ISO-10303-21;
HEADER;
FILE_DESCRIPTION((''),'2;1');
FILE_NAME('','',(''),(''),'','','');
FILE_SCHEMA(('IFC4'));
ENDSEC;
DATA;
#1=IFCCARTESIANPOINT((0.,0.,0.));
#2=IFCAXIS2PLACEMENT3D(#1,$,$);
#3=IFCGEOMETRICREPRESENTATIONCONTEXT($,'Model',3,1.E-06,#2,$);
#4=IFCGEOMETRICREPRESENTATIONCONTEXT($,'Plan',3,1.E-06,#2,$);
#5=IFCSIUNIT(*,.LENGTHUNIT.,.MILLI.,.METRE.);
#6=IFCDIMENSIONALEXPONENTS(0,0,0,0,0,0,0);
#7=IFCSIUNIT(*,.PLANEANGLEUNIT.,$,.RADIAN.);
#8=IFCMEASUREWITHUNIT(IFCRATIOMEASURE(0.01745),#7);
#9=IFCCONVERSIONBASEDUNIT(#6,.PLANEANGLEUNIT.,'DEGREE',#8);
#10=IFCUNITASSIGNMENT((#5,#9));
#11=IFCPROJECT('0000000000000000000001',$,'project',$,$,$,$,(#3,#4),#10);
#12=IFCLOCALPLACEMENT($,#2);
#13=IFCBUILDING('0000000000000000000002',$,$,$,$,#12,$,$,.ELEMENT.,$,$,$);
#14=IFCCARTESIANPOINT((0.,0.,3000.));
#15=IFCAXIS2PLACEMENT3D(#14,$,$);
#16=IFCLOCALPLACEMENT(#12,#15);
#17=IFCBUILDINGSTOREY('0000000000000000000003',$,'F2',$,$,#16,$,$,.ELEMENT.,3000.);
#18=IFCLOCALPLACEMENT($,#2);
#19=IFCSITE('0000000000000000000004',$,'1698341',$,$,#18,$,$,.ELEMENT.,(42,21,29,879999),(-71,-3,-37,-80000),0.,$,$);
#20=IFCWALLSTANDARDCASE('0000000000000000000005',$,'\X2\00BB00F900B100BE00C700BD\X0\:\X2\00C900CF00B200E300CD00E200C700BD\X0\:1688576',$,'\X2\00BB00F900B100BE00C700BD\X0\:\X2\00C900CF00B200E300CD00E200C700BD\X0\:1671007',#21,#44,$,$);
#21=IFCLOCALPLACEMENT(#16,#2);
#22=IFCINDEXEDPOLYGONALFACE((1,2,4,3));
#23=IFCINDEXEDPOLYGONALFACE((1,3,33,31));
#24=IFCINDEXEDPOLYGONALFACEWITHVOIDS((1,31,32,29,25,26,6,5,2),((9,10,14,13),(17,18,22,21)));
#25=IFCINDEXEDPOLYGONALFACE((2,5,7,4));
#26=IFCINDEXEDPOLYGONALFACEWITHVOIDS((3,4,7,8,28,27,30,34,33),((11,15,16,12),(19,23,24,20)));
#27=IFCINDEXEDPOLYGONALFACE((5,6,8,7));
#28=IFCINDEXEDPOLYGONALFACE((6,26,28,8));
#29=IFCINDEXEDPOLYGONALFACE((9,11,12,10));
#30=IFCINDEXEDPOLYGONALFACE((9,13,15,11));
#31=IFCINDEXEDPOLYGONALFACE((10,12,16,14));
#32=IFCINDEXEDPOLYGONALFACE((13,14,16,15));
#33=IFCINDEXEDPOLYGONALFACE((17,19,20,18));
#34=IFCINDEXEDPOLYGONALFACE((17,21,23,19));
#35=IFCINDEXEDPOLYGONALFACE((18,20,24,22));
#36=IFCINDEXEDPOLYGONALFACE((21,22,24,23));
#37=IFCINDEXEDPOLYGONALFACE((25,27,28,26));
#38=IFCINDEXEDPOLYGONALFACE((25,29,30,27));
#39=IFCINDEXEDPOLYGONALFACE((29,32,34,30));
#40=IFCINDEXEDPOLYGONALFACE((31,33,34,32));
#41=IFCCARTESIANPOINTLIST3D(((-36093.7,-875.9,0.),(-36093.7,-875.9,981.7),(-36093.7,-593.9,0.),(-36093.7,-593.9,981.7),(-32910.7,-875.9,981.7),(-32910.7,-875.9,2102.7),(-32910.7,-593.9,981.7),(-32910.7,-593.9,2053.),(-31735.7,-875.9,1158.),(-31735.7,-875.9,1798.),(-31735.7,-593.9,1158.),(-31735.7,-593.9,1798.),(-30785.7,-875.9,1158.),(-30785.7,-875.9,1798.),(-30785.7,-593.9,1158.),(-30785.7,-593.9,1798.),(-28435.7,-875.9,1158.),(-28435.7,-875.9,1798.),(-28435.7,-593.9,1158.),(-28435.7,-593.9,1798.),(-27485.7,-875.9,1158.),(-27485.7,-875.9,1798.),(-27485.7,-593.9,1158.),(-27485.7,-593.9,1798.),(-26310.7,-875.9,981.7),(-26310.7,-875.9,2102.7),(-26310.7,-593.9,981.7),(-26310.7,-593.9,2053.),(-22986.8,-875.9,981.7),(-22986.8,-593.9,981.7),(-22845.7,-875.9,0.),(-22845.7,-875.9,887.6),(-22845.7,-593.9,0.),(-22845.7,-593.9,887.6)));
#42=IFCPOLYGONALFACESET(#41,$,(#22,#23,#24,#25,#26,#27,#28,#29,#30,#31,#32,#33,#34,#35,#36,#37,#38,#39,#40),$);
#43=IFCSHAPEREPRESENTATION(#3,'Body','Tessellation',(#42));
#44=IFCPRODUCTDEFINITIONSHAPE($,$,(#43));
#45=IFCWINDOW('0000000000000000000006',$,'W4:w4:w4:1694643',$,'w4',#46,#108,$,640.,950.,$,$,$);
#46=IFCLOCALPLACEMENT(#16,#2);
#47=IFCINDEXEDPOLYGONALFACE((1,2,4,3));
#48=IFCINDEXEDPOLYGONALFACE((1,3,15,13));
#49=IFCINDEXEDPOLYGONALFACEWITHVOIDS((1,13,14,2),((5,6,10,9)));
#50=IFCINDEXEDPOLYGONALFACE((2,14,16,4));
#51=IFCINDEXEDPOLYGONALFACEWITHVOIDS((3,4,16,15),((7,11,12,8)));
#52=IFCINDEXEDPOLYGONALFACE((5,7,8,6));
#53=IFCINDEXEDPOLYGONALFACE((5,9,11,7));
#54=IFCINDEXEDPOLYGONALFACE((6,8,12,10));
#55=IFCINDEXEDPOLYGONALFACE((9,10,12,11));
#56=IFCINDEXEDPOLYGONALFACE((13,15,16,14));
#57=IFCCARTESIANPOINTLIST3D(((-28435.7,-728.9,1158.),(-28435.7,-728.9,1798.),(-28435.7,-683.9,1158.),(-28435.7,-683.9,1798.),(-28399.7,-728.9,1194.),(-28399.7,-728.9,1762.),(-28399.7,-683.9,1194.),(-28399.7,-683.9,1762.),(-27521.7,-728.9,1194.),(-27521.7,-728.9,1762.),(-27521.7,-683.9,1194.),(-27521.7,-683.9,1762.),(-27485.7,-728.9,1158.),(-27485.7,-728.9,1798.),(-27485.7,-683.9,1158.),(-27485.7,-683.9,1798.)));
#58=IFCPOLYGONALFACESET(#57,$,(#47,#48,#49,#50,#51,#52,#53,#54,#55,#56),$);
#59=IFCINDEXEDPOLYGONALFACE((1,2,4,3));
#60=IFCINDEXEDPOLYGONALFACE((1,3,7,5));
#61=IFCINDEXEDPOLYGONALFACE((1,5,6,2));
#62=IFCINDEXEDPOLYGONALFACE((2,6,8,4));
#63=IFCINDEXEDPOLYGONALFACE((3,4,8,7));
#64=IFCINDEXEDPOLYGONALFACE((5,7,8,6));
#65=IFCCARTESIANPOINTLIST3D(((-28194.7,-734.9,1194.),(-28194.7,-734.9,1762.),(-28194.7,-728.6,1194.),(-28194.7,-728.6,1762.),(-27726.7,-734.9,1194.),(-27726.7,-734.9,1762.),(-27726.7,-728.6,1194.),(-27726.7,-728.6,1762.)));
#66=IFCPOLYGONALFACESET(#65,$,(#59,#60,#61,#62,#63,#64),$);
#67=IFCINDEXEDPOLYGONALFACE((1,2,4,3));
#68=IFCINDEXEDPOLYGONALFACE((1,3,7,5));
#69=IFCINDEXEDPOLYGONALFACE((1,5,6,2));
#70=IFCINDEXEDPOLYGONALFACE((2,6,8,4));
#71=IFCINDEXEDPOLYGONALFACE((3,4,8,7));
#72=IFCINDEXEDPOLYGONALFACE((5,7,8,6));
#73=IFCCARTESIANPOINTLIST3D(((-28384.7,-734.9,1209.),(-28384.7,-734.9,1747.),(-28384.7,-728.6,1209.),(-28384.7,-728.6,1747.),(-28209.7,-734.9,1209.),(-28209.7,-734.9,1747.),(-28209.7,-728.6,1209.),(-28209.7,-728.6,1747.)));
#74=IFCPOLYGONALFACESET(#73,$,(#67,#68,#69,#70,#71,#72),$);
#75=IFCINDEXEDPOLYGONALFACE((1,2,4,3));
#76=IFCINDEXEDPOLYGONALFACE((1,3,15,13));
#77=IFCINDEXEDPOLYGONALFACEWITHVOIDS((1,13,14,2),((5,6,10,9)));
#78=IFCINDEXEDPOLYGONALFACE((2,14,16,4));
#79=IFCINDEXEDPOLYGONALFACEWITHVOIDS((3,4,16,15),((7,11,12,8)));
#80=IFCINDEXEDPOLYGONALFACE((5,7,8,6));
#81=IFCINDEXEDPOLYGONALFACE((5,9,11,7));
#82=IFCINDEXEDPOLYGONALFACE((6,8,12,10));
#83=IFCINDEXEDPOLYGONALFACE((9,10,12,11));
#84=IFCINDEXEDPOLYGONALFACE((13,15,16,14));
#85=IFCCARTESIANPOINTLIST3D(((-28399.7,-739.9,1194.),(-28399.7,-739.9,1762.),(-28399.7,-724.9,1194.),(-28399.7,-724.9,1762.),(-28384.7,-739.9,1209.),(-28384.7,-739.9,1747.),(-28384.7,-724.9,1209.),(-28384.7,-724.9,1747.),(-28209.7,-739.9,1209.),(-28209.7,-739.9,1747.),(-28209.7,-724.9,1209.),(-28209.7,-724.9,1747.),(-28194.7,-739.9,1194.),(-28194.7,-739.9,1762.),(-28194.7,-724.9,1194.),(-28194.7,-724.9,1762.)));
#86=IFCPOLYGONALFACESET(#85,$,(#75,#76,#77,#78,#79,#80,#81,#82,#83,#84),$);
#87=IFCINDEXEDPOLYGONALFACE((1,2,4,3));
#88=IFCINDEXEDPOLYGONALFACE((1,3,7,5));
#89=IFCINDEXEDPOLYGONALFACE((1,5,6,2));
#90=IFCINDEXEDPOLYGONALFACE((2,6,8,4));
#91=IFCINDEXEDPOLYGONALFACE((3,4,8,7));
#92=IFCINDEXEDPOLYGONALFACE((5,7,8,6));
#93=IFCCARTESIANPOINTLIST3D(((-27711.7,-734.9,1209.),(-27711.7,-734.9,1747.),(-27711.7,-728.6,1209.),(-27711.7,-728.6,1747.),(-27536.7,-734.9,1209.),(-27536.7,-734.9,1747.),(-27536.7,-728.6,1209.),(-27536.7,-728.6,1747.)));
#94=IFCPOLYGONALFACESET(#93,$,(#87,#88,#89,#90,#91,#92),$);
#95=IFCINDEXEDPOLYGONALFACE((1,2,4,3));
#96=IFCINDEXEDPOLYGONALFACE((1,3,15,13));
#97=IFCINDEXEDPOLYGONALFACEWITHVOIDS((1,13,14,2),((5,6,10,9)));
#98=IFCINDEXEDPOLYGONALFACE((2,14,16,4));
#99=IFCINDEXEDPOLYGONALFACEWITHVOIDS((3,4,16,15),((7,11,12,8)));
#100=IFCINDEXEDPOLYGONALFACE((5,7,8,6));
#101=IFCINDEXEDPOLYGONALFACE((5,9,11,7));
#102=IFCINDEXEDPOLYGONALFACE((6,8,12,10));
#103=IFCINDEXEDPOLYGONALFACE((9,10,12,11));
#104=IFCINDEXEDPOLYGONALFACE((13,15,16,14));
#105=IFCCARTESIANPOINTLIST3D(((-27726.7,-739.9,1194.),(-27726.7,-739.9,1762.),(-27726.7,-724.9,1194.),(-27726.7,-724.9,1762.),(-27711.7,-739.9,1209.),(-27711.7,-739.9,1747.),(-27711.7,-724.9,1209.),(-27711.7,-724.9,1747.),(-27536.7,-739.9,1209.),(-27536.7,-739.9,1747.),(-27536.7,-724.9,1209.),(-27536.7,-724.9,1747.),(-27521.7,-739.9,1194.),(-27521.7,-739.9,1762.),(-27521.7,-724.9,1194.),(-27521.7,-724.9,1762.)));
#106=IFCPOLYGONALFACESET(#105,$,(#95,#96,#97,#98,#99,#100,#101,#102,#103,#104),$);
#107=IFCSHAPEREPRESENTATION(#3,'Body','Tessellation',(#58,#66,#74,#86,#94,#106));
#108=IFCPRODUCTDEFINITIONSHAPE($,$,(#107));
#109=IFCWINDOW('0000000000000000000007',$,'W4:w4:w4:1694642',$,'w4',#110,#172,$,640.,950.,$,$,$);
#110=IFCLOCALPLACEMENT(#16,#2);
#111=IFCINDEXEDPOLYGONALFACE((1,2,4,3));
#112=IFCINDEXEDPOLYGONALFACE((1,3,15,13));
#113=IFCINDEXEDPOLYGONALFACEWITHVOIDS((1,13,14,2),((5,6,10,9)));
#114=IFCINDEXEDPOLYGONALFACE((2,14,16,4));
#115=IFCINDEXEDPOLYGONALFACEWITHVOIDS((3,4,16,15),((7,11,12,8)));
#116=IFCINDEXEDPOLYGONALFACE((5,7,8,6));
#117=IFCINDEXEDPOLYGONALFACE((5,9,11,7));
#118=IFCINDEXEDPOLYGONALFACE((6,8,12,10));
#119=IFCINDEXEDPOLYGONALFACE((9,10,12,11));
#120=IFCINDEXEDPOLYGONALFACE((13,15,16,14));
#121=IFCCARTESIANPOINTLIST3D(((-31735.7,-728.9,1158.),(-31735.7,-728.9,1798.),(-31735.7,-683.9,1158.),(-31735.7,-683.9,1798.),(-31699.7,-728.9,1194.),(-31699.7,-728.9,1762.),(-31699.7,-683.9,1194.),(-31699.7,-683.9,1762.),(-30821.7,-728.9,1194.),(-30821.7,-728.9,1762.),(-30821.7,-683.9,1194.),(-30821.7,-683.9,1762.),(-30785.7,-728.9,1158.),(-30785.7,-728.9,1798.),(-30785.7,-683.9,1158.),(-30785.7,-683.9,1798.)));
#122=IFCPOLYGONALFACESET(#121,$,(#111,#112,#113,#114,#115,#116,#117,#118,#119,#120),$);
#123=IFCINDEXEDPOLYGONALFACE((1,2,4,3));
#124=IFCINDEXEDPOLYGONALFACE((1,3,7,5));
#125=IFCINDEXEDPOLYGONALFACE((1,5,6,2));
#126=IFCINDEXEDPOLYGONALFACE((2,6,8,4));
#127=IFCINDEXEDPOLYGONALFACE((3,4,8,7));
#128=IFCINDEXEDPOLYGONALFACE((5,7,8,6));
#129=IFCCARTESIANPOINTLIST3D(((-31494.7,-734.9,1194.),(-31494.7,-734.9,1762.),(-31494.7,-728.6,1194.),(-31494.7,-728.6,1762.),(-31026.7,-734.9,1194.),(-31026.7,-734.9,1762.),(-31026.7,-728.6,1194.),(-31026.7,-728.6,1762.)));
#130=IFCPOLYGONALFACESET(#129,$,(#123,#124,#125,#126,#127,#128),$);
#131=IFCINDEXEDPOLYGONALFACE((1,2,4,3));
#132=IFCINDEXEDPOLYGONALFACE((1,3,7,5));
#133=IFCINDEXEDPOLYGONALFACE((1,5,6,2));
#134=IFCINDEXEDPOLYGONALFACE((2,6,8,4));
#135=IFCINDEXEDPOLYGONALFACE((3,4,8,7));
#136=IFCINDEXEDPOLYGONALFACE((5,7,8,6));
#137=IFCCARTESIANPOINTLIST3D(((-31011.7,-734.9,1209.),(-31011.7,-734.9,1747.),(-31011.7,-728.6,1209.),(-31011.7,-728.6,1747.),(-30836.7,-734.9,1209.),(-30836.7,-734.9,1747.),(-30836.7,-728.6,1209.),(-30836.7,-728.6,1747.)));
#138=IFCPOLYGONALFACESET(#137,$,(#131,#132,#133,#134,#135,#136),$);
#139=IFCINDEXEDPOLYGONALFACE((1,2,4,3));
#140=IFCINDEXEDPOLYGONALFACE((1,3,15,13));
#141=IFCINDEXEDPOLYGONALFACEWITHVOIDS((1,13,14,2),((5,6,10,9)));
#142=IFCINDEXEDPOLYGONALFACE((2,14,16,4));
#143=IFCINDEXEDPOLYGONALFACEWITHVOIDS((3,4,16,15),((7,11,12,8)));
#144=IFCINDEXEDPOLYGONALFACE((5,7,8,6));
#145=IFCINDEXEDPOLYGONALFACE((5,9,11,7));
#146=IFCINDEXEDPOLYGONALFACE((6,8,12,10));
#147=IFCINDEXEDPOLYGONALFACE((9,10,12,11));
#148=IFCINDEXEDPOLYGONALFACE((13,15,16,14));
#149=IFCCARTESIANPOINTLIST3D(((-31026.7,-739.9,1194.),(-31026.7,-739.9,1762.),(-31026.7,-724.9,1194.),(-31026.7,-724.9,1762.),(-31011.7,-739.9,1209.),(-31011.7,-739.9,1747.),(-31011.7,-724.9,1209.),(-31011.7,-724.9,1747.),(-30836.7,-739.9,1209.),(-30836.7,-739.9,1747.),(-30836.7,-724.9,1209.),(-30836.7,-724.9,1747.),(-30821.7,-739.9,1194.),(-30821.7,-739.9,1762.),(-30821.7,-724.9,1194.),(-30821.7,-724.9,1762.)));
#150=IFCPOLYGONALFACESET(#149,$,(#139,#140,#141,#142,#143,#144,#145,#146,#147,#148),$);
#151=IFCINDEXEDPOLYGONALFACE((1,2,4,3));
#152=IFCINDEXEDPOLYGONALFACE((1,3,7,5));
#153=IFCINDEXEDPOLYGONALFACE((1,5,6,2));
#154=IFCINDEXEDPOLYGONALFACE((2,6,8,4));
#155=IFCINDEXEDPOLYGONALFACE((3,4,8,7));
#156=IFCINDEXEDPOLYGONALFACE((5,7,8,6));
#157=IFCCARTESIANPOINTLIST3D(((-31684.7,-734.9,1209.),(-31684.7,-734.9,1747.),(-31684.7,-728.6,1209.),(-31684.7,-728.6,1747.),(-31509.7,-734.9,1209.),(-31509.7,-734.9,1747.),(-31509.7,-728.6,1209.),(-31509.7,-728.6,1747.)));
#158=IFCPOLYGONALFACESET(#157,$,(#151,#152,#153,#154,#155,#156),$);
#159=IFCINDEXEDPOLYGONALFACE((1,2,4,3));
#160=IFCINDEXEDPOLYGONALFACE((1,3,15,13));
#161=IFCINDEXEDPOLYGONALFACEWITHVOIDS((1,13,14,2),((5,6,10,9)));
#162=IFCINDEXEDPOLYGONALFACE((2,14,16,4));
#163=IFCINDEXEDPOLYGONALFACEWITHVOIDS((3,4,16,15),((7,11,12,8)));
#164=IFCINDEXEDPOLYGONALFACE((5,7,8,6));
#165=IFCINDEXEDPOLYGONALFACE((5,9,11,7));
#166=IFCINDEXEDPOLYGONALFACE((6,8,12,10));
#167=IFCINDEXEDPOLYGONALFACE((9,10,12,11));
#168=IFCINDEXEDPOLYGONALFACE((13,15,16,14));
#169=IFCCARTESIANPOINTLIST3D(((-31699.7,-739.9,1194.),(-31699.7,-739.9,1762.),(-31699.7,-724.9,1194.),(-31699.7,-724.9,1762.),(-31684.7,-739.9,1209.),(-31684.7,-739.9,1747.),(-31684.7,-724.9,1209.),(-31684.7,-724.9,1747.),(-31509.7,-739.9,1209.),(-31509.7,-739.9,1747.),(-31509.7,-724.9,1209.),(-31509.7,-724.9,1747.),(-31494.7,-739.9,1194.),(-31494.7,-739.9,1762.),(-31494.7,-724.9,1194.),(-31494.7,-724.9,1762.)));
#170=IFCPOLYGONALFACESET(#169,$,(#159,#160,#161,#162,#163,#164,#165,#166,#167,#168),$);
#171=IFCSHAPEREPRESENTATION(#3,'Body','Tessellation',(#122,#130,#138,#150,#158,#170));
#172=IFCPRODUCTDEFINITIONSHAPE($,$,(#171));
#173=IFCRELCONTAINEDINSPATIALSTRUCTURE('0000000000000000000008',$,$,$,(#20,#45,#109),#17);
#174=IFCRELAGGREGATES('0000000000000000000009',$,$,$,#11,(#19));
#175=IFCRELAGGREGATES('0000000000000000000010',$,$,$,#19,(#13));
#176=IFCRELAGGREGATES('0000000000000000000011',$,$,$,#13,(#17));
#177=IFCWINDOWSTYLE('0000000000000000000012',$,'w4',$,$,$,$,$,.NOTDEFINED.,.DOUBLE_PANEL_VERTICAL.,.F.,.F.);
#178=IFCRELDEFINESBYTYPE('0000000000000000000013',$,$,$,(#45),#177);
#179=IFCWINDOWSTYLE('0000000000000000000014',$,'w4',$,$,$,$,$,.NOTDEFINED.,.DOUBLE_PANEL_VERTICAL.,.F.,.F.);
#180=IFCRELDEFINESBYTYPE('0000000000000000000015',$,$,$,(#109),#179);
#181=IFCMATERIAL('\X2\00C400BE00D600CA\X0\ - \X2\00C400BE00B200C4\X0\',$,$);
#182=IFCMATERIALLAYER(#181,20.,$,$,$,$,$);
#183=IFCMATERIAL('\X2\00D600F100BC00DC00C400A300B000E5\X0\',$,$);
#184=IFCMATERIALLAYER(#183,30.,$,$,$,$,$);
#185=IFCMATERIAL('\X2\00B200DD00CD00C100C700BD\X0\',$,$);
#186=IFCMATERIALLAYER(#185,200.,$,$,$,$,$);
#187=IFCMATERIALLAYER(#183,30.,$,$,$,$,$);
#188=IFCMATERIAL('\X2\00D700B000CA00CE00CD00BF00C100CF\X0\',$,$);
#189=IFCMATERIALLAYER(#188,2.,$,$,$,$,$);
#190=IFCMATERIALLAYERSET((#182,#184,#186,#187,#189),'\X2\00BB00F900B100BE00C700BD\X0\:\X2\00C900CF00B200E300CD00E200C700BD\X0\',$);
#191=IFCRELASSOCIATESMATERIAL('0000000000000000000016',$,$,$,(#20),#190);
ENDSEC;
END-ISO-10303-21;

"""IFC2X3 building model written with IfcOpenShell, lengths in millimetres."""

from ifc_helpers import new_model, entity, si_unit, converted_unit, frame, frame_2d, origin, origin_2d_with_axis, place, context, project, spatial, polyline, rectangle, outline, extrude, clip, halfspace, bounded_halfspace, source, transform, mapped, material, layer, layer_set, layer_usage, type_object, type_shapes, element, fill, save


model = new_model("IFC2X3")

# Units and contexts
model_context = context("Model", 3, precision=1e-06, world=origin())
plan_context = context("Plan", 3, precision=1e-06, world=origin())
ifc_project = project(units=[si_unit("LENGTHUNIT", "METRE", prefix="MILLI"), converted_unit("PLANEANGLEUNIT", "DEGREE", entity("IfcRatioMeasure", 0.01745), si_unit("PLANEANGLEUNIT", "RADIAN"), dimensions=[0, 0, 0, 0, 0, 0, 0])], contexts=[model_context, plan_context])

# Site, building, storey
site_placement = place(None, origin())
site = spatial("IfcSite", under=ifc_project, at=site_placement, Name="1698341", CompositionType="ELEMENT", RefLatitude=(42, 21, 29, 879999), RefLongitude=(-71, -3, -37, -80000), RefElevation=0.0)
building_placement = place(None, origin())
building = spatial("IfcBuilding", under=site, at=building_placement, CompositionType="ELEMENT")
storey_placement = place(building_placement, frame((0.0, 0.0, 3000.0)))
storey = spatial("IfcBuildingStorey", under=building, at=storey_placement, Name="F2", CompositionType="ELEMENT", Elevation=3000.0)

# Shared definitions
ifc_material_1 = material(Name="Öñ¼ÜÄ£°å")

# Shared definitions
ifc_material_2 = material(Name="Ä¾ÖÊ - Ä¾²Ä")
ifc_layer_1 = layer(ifc_material_2, 20.0)
ifc_layer_2 = layer(ifc_material_1, 30.0)
ifc_material_3 = material(Name="²ÝÍÁÇ½")
ifc_layer_3 = layer(ifc_material_3, 200.0)
ifc_layer_4 = layer(ifc_material_1, 30.0)
ifc_material_4 = material(Name="×°ÊÎÍ¿ÁÏ")
ifc_layer_5 = layer(ifc_material_4, 2.0)
ifc_layer_set_1 = layer_set([ifc_layer_1, ifc_layer_2, ifc_layer_3, ifc_layer_4, ifc_layer_5], Name="»ù±¾Ç½:ÉÏ²ãÍâÇ½")

# Wall, openings, windows
ifc_layer_usage_1 = layer_usage(ifc_layer_set_1, "AXIS2", "NEGATIVE", 141.0)
wall_1_placement = place(storey_placement, frame((-36093.7, -734.9, 0.0)))
wall_1 = element("IfcWallStandardCase", 1, at=wall_1_placement, inside=storey, material=ifc_layer_usage_1, Name="»ù±¾Ç½:ÉÏ²ãÍâÇ½:1688576", ObjectType="»ù±¾Ç½:ÉÏ²ãÍâÇ½:1671007", context=model_context, shape_type="Clipping", body=[
    clip(clip(clip(extrude(rectangle(XDim=13248.0, YDim=282.0, at=frame_2d((6624.0, 0.0), x_axis=(-1.0, 0.0))), origin(), (0.0, 0.0, 1.0), 3200.0), bounded_halfspace(frame((3098.0, -141.0, 2102.7), z_axis=(0.0, -0.1736, -0.9848), x_axis=(-1.0, 0.0, 0.0)), True, frame((3098.0, -141.0, 2102.7)), polyline([(0.0, 0.0), (170.0, 0.0), (3280.0, 0.0), (3490.0, 0.0), (6600.0, 0.0), (6770.0, 0.0), (6770.0, 282.0), (0.0, 282.0), (0.0, 0.0)]))), halfspace(frame((13107.0, 0.0, 981.7), z_axis=(0.5551, 0.0, 0.8318), x_axis=(0.0, 1.0, 0.0)), False)), halfspace(frame((3183.0, 0.0, 3200.0), z_axis=(-0.5551, 0.0, 0.8318), x_axis=(0.0, 1.0, 0.0)), False)),
])
opening_1_placement = place(wall_1_placement, origin())
opening_1 = element("IfcOpeningElement", 2, at=opening_1_placement, cuts=wall_1, ObjectType="Opening", context=model_context, shape_type="SweptSolid", body=[
    extrude(rectangle(XDim=640.0, YDim=950.0, at=origin_2d_with_axis()), frame((4833.0, -141.0, 1478.0), z_axis=(0.0, 1.0, 0.0), x_axis=(0.0, 0.0, 1.0)), (0.0, 0.0, 1.0), 282.0),
])
opening_2_placement = place(wall_1_placement, origin())
opening_2 = element("IfcOpeningElement", 3, at=opening_2_placement, cuts=wall_1, ObjectType="Opening", context=model_context, shape_type="SweptSolid", body=[
    extrude(rectangle(XDim=640.0, YDim=950.0, at=frame_2d((0.0, 0.0), x_axis=(0.0, 1.0))), frame((8133.0, -141.0, 1478.0), z_axis=(0.0, 1.0, 0.0), x_axis=(-1.0, 0.0, 0.0)), (0.0, 0.0, 1.0), 282.0),
])
opening_3_placement = place(wall_1_placement, frame((10891.0, 141.0, 1721.1)))
element("IfcOpeningElement", 4, at=opening_3_placement, cuts=wall_1, ObjectType="Opening", context=model_context, shape_type="SweptSolid", body=[
    extrude(outline(polyline([(-2253.7, -615.1), (1742.5, -615.1), (511.2, 1230.1), (-2253.7, -615.1)])), frame((0.0, 0.0, 0.0), z_axis=(0.0, -1.0, 0.0), x_axis=(-0.8318, 0.0, 0.5551)), (0.0, 0.0, 1.0), 282.0),
])
opening_4_placement = place(wall_1_placement, frame((2075.0, 141.0, 1721.1)))
element("IfcOpeningElement", 5, at=opening_4_placement, cuts=wall_1, ObjectType="Opening", context=model_context, shape_type="SweptSolid", body=[
    extrude(outline(polyline([(-1742.5, -615.1), (2253.7, -615.1), (-511.2, 1230.1), (-1742.5, -615.1)])), frame((0.0, 0.0, 0.0), z_axis=(0.0, -1.0, 0.0), x_axis=(-0.8318, 0.0, -0.5551)), (0.0, 0.0, 1.0), 282.0),
])
window_style_1 = type_object("IfcWindowStyle", Name="w4", ConstructionType="NOTDEFINED", OperationType="DOUBLE_PANEL_VERTICAL", ParameterTakesPrecedence=False, Sizeable=False)
shared_shape_1 = source(origin(), model_context, "Body", "SweptSolid", [
    extrude(outline(polyline([(-320.0, -475.0), (320.0, -475.0), (320.0, 475.0), (-320.0, 475.0), (-320.0, -475.0)]), holes=[polyline([(284.0, -439.0), (-284.0, -439.0), (-284.0, 439.0), (284.0, 439.0), (284.0, -439.0)])]), frame((475.0, -135.0, 320.0), z_axis=(0.0, 1.0, 0.0), x_axis=(0.0, 0.0, 1.0)), (0.0, 0.0, 1.0), 45.0),
    extrude(rectangle(XDim=6.3, YDim=468.0, at=origin_2d_with_axis()), frame((475.0, -137.9, 36.0), z_axis=(0.0, 0.0, 1.0), x_axis=(0.0, 1.0, 0.0)), (0.0, 0.0, 1.0), 568.0),
    extrude(rectangle(XDim=6.3, YDim=175.0, at=origin_2d_with_axis()), frame((138.5, -137.9, 51.0), z_axis=(0.0, 0.0, 1.0), x_axis=(0.0, 1.0, 0.0)), (0.0, 0.0, 1.0), 538.0),
    extrude(outline(polyline([(-102.5, -284.0), (102.5, -284.0), (102.5, 284.0), (-102.5, 284.0), (-102.5, -284.0)]), holes=[polyline([(87.5, -269.0), (-87.5, -269.0), (-87.5, 269.0), (87.5, 269.0), (87.5, -269.0)])]), frame((138.5, -146.0, 320.0), z_axis=(0.0, 1.0, 0.0), x_axis=(-1.0, 0.0, 0.0)), (0.0, 0.0, 1.0), 15.0),
    extrude(rectangle(XDim=6.3, YDim=175.0, at=origin_2d_with_axis()), frame((811.5, -137.9, 51.0), z_axis=(0.0, 0.0, 1.0), x_axis=(0.0, 1.0, 0.0)), (0.0, 0.0, 1.0), 538.0),
    extrude(outline(polyline([(-102.5, -284.0), (102.5, -284.0), (102.5, 284.0), (-102.5, 284.0), (-102.5, -284.0)]), holes=[polyline([(87.5, -269.0), (-87.5, -269.0), (-87.5, 269.0), (87.5, 269.0), (87.5, -269.0)])]), frame((811.5, -146.0, 320.0), z_axis=(0.0, 1.0, 0.0), x_axis=(-1.0, 0.0, 0.0)), (0.0, 0.0, 1.0), 15.0),
])
type_shapes(window_style_1, [shared_shape_1])
window_1_placement = place(opening_2_placement, frame((7658.0, 141.0, 1158.0)))
window_1 = element("IfcWindow", 6, at=window_1_placement, inside=storey, type_object=window_style_1, Name="W4:w4:w4:1694643", ObjectType="w4", OverallHeight=640.0, OverallWidth=950.0, context=model_context, shape_type="MappedRepresentation", body=[
    mapped(shared_shape_1, transform((0.0, 0.0, 0.0), scale=1.0)),
])
fill(opening_2, window_1)
window_style_2 = type_object("IfcWindowStyle", Name="w4", ConstructionType="NOTDEFINED", OperationType="DOUBLE_PANEL_VERTICAL", ParameterTakesPrecedence=False, Sizeable=False)
shared_shape_2 = source(origin(), model_context, "Body", "SweptSolid", [
    extrude(outline(polyline([(-475.0, -320.0), (475.0, -320.0), (475.0, 320.0), (-475.0, 320.0), (-475.0, -320.0)]), holes=[polyline([(-439.0, 284.0), (439.0, 284.0), (439.0, -284.0), (-439.0, -284.0), (-439.0, 284.0)])]), frame((-177.3, 192.0, 320.0), z_axis=(0.0, -1.0, 0.0), x_axis=(-1.0, 0.0, 0.0)), (0.0, 0.0, 1.0), 45.0),
    extrude(rectangle(XDim=468.0, YDim=6.3, at=origin_2d_with_axis()), frame((-177.3, 144.1, 36.0)), (0.0, 0.0, 1.0), 568.0),
    extrude(rectangle(XDim=175.0, YDim=6.3, at=origin_2d_with_axis()), frame((159.2, 144.1, 51.0)), (0.0, 0.0, 1.0), 538.0),
    extrude(outline(polyline([(-284.0, -102.5), (284.0, -102.5), (284.0, 102.5), (-284.0, 102.5), (-284.0, -102.5)]), holes=[polyline([(-269.0, 87.5), (269.0, 87.5), (269.0, -87.5), (-269.0, -87.5), (-269.0, 87.5)])]), frame((159.2, 151.0, 320.0), z_axis=(0.0, -1.0, 0.0), x_axis=(0.0, 0.0, 1.0)), (0.0, 0.0, 1.0), 15.0),
    extrude(rectangle(XDim=175.0, YDim=6.3, at=origin_2d_with_axis()), frame((-513.8, 144.1, 51.0)), (0.0, 0.0, 1.0), 538.0),
    extrude(outline(polyline([(-284.0, -102.5), (284.0, -102.5), (284.0, 102.5), (-284.0, 102.5), (-284.0, -102.5)]), holes=[polyline([(-269.0, 87.5), (269.0, 87.5), (269.0, -87.5), (-269.0, -87.5), (-269.0, 87.5)])]), frame((-513.8, 151.0, 320.0), z_axis=(0.0, -1.0, 0.0), x_axis=(0.0, 0.0, 1.0)), (0.0, 0.0, 1.0), 15.0),
])
type_shapes(window_style_2, [shared_shape_2])
window_2_placement = place(opening_1_placement, frame((5010.3, -141.0, 1158.0)))
window_2 = element("IfcWindow", 7, at=window_2_placement, inside=storey, type_object=window_style_2, Name="W4:w4:w4:1694642", ObjectType="w4", OverallHeight=640.0, OverallWidth=950.0, context=model_context, shape_type="MappedRepresentation", body=[
    mapped(shared_shape_2, transform((0.0, 0.0, 0.0), scale=1.0)),
])
fill(opening_1, window_2)

save(model, "model.ifc")
